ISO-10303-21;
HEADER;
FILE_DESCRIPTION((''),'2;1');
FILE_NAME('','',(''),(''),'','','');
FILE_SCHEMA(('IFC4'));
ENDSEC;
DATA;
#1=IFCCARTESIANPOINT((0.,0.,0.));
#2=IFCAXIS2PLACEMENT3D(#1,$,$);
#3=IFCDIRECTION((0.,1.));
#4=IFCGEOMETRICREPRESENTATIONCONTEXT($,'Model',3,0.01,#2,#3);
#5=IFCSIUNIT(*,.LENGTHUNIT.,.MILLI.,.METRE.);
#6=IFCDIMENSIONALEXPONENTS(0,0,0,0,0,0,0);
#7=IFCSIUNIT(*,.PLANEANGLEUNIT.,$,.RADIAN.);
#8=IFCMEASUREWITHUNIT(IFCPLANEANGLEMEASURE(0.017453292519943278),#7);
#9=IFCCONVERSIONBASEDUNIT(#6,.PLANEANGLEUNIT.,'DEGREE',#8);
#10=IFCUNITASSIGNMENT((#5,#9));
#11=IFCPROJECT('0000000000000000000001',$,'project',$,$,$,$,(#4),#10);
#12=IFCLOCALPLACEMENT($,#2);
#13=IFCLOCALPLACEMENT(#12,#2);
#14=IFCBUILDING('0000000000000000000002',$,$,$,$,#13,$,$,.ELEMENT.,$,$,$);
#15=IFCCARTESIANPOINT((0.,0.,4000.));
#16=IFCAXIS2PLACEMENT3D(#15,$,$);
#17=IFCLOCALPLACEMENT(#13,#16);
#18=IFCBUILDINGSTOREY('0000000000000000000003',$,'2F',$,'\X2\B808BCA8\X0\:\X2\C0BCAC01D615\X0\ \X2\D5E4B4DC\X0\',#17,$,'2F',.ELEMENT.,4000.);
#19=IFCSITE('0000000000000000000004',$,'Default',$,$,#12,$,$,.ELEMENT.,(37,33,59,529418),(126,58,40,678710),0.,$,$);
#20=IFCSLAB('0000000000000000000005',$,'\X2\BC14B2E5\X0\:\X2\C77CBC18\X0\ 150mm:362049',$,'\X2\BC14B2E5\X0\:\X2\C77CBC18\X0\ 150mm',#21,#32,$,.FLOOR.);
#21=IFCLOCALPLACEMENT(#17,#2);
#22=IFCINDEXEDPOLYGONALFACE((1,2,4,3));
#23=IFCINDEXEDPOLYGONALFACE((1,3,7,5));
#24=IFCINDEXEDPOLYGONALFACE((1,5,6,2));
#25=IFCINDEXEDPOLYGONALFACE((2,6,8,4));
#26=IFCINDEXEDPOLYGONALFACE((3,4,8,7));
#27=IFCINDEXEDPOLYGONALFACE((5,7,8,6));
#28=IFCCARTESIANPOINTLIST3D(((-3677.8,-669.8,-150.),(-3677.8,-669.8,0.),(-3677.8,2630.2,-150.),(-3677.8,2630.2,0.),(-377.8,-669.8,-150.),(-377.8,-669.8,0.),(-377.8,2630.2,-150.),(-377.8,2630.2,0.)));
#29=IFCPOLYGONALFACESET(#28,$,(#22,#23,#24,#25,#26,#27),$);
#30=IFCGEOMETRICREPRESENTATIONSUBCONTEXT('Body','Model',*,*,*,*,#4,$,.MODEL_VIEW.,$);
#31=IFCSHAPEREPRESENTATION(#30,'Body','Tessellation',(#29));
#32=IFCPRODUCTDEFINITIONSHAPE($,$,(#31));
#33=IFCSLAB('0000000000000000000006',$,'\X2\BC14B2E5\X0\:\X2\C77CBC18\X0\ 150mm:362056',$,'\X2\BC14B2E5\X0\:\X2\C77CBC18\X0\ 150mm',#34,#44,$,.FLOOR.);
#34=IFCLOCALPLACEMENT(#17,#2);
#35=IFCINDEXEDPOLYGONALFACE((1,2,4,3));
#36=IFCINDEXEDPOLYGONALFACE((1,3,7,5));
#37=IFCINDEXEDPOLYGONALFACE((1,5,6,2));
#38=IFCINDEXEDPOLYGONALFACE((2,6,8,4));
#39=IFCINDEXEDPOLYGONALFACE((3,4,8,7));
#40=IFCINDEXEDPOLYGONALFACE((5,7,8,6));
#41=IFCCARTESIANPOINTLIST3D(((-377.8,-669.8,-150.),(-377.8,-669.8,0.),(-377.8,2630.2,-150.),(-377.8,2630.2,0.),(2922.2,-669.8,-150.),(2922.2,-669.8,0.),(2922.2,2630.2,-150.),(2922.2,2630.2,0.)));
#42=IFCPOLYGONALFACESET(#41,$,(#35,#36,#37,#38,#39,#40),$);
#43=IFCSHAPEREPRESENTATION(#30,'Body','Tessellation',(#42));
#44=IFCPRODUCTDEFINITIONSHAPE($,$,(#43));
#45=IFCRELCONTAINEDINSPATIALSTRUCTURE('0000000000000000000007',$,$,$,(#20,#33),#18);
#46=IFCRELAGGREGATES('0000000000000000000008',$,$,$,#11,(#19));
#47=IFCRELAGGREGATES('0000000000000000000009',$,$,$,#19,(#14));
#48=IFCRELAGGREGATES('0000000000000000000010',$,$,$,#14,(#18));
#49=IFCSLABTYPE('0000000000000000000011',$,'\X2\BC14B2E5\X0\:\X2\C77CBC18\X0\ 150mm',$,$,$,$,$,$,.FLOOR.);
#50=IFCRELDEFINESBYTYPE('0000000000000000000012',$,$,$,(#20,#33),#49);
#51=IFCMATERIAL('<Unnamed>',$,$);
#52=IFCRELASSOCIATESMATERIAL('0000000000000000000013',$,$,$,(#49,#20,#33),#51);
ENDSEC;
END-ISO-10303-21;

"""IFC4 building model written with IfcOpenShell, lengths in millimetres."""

from ifc_helpers import new_model, entity, si_unit, converted_unit, direction, frame, origin, place, context, subcontext, project, spatial, indexed_curve, outline, extrude, material, type_object, element, save


model = new_model("IFC4")

# Units and contexts
model_context = context("Model", 3, precision=0.01, world=origin(), true_north=direction((0.0, 1.0)))
body_context = subcontext(model_context, "Body", "Model", "MODEL_VIEW")
ifc_project = project(units=[si_unit("LENGTHUNIT", "METRE", prefix="MILLI"), converted_unit("PLANEANGLEUNIT", "DEGREE", entity("IfcPlaneAngleMeasure", 0.017453292519943278), si_unit("PLANEANGLEUNIT", "RADIAN"), dimensions=[0, 0, 0, 0, 0, 0, 0])], contexts=[model_context])

# Site, building, storey
site_placement = place(None, origin())
site = spatial("IfcSite", under=ifc_project, at=site_placement, Name="Default", CompositionType="ELEMENT", RefLatitude=(37, 33, 59, 529418), RefLongitude=(126, 58, 40, 678710), RefElevation=0.0)
building_placement = place(site_placement, origin())
building = spatial("IfcBuilding", under=site, at=building_placement, CompositionType="ELEMENT")
storey_placement = place(building_placement, frame((0.0, 0.0, 4000.0)))
storey = spatial("IfcBuildingStorey", under=building, at=storey_placement, Name="2F", ObjectType="레벨:삼각형 헤드", LongName="2F", CompositionType="ELEMENT", Elevation=4000.0)

# Slabs
ifc_material = material(Name="<Unnamed>")
slab_type = type_object("IfcSlabType", Name="바닥:일반 150mm", PredefinedType="FLOOR", material=ifc_material)
slab_1_placement = place(storey_placement, origin())
element("IfcSlab", 1, at=slab_1_placement, inside=storey, type_object=slab_type, material=ifc_material, Name="바닥:일반 150mm:362049", ObjectType="바닥:일반 150mm", PredefinedType="FLOOR", context=body_context, shape_type="SweptSolid", body=[
    extrude(outline(indexed_curve([(-1650.0, -1650.0), (1650.0, -1650.0), (1650.0, 1650.0), (-1650.0, 1650.0), (-1650.0, -1650.0)], self_intersect=False)), frame((-2027.8, 980.2, 0.0), z_axis=(0.0, 0.0, -1.0), x_axis=(0.0, 1.0, 0.0)), (0.0, 0.0, 1.0), 150.0),
])
slab_2_placement = place(storey_placement, origin())
element("IfcSlab", 2, at=slab_2_placement, inside=storey, type_object=slab_type, material=ifc_material, Name="바닥:일반 150mm:362056", ObjectType="바닥:일반 150mm", PredefinedType="FLOOR", context=body_context, shape_type="SweptSolid", body=[
    extrude(outline(indexed_curve([(-1650.0, -1650.0), (1650.0, -1650.0), (1650.0, 1650.0), (-1650.0, 1650.0), (-1650.0, -1650.0)], self_intersect=False)), frame((1272.2, 980.2, 0.0), z_axis=(0.0, 0.0, -1.0), x_axis=(0.0, 1.0, 0.0)), (0.0, 0.0, 1.0), 150.0),
])

save(model, "model.ifc")
